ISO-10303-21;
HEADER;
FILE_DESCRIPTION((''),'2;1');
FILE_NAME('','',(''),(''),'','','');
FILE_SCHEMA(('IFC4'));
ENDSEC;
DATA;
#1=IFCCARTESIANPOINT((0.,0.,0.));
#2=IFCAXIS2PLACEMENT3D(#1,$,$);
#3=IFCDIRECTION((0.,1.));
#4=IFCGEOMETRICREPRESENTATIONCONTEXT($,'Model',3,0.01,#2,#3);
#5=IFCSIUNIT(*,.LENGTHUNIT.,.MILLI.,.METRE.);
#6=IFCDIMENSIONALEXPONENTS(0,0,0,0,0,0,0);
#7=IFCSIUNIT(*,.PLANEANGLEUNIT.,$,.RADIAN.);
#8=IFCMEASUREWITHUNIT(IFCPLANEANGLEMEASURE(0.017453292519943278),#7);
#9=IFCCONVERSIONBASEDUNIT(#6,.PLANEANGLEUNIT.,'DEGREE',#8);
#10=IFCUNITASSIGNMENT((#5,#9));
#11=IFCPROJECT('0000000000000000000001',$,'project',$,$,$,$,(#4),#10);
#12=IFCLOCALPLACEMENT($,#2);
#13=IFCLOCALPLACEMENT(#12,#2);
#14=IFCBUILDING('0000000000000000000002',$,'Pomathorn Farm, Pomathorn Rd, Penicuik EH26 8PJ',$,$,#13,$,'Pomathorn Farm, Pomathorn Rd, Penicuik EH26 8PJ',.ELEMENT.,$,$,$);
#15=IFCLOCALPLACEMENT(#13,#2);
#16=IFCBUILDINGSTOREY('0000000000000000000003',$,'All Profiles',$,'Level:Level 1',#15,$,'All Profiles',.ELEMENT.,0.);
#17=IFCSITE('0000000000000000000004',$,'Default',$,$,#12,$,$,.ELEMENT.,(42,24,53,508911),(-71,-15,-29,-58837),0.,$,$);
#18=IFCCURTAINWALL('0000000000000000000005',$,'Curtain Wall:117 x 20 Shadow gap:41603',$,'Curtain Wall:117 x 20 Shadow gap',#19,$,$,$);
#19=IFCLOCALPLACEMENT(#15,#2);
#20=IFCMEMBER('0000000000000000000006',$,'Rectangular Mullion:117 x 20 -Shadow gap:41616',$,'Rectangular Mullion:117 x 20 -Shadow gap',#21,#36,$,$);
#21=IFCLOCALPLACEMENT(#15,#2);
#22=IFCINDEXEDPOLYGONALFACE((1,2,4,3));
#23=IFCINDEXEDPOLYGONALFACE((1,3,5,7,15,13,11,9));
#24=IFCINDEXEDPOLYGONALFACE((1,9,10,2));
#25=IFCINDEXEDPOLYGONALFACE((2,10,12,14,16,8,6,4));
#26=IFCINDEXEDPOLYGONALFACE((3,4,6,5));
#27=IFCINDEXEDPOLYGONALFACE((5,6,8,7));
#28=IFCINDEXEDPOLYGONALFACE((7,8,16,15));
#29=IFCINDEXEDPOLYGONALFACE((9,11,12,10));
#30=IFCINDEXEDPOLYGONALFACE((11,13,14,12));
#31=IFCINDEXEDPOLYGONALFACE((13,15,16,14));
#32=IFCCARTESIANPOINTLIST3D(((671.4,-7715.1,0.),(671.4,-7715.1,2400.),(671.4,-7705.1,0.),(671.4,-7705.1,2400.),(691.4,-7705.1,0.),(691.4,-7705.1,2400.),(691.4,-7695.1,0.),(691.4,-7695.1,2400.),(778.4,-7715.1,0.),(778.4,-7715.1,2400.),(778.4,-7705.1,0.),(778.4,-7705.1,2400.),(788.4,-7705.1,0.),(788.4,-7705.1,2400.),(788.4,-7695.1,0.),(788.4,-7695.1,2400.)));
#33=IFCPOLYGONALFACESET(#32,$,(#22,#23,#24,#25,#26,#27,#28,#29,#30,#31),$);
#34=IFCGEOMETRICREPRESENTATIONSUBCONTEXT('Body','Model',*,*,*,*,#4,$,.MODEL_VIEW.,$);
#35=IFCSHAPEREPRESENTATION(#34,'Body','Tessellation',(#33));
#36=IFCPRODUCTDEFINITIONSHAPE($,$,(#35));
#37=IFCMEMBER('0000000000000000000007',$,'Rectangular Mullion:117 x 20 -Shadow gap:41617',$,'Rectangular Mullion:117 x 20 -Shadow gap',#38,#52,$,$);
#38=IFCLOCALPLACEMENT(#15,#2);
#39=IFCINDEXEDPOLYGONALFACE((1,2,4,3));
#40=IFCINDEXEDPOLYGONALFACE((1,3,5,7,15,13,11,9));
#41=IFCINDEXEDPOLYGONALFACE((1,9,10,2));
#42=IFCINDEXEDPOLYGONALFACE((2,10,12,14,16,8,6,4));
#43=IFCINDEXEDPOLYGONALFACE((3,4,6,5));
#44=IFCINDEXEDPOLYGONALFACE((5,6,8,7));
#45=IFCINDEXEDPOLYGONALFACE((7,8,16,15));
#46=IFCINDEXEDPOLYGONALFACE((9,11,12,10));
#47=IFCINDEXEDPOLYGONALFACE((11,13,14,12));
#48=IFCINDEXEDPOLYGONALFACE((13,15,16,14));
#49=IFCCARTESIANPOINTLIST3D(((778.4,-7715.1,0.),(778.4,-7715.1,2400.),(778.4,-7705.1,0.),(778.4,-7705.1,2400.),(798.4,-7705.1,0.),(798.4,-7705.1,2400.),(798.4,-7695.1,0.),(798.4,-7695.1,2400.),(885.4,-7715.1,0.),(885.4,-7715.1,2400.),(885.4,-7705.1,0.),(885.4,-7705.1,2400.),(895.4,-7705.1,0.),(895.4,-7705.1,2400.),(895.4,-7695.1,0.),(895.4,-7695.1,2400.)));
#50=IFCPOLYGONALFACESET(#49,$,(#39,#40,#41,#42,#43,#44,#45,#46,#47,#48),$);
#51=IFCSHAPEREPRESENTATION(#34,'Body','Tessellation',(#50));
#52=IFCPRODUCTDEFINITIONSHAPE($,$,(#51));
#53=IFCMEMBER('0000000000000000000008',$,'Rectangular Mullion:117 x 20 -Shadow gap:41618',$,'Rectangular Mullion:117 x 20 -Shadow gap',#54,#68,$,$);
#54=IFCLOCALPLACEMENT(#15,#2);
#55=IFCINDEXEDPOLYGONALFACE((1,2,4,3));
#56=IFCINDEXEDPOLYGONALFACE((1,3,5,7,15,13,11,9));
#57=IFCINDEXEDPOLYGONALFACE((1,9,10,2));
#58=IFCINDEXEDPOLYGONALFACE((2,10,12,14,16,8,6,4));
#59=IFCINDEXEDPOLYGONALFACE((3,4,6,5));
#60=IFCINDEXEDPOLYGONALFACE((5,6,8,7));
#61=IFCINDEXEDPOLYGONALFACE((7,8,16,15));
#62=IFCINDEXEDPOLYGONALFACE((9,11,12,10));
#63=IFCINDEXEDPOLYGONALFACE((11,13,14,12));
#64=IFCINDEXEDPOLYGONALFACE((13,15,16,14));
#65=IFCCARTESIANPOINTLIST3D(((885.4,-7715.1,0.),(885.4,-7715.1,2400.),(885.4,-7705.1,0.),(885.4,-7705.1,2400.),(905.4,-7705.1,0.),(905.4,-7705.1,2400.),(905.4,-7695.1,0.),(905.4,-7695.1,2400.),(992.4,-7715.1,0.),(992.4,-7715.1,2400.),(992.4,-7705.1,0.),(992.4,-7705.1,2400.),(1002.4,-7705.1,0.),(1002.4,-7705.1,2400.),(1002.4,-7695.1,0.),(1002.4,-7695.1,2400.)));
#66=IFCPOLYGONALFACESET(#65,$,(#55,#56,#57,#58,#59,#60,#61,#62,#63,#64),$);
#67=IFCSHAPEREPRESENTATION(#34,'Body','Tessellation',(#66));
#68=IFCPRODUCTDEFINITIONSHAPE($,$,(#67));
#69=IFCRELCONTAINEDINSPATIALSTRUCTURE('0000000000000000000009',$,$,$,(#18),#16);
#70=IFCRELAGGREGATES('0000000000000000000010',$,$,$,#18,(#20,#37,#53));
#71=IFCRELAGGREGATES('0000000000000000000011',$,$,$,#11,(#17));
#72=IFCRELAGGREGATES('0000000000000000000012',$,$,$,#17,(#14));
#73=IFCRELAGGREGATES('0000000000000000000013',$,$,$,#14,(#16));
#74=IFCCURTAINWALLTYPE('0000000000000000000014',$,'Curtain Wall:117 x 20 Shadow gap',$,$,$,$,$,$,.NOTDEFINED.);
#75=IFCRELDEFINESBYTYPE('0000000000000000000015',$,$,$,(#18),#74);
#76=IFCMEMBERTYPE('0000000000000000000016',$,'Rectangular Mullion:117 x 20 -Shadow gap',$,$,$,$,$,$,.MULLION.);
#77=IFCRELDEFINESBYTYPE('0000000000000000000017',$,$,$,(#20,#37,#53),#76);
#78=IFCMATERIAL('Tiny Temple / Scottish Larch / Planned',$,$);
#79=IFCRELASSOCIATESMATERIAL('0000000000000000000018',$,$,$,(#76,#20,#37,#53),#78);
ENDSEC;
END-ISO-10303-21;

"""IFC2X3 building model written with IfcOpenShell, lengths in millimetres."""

from ifc_helpers import new_model, entity, si_unit, converted_unit, direction, frame, origin, place, context, subcontext, project, spatial, polyline, outline, extrude, source, transform, mapped, material, type_object, type_shapes, element, aggregate, save


model = new_model("IFC2X3")

# Units and contexts
model_context = context("Model", 3, precision=0.01, world=origin(), true_north=direction((0.0, 1.0)))
body_context = subcontext(model_context, "Body", "Model", "MODEL_VIEW")
ifc_project = project(units=[si_unit("LENGTHUNIT", "METRE", prefix="MILLI"), converted_unit("PLANEANGLEUNIT", "DEGREE", entity("IfcPlaneAngleMeasure", 0.017453292519943278), si_unit("PLANEANGLEUNIT", "RADIAN"), dimensions=[0, 0, 0, 0, 0, 0, 0])], contexts=[model_context])

# Site, building, storey
site_placement = place(None, origin())
site = spatial("IfcSite", under=ifc_project, at=site_placement, Name="Default", CompositionType="ELEMENT", RefLatitude=(42, 24, 53, 508911), RefLongitude=(-71, -15, -29, -58837), RefElevation=0.0)
building_placement = place(site_placement, origin())
building = spatial("IfcBuilding", under=site, at=building_placement, Name="Pomathorn Farm, Pomathorn Rd, Penicuik EH26 8PJ", LongName="Pomathorn Farm, Pomathorn Rd, Penicuik EH26 8PJ", CompositionType="ELEMENT")
storey_placement = place(building_placement, origin())
storey = spatial("IfcBuildingStorey", under=building, at=storey_placement, Name="All Profiles", ObjectType="Level:Level 1", LongName="All Profiles", CompositionType="ELEMENT", Elevation=0.0)

# Curtain wall, members
ifc_material = material(Name="Tiny Temple / Scottish Larch / Planned")
curtain_wall_type_1 = type_object("IfcCurtainWallType", Name="Curtain Wall:117 x 20 Shadow gap", PredefinedType="NOTDEFINED")
curtain_wall_1_placement = place(storey_placement, origin())
curtain_wall_1 = element("IfcCurtainWall", 1, at=curtain_wall_1_placement, inside=storey, type_object=curtain_wall_type_1, Name="Curtain Wall:117 x 20 Shadow gap:41603", ObjectType="Curtain Wall:117 x 20 Shadow gap")
member_type_1 = type_object("IfcMemberType", Name="Rectangular Mullion:117 x 20 -Shadow gap", PredefinedType="MULLION", material=ifc_material)
shared_shape_1 = source(origin(), body_context, "Body", "SweptSolid", [
    extrude(outline(polyline([(-61.0, 0.0), (-61.0, -10.0), (46.0, -10.0), (46.0, 0.0), (56.0, 0.0), (56.0, 10.0), (-41.0, 10.0), (-41.0, 0.0), (-61.0, 0.0)])), frame((-56.0, -10.0, -2400.0), z_axis=(0.0, 0.0, -1.0), x_axis=(1.0, 0.0, 0.0)), (0.0, 0.0, -1.0), 2400.0),
])
type_shapes(member_type_1, [shared_shape_1])
member_1_placement = place(curtain_wall_1_placement, frame((788.4, -7715.1, 0.0), z_axis=(0.0, 0.0, -1.0), x_axis=(1.0, 0.0, 0.0)))
member_1 = element("IfcMember", 2, at=member_1_placement, type_object=member_type_1, material=ifc_material, Name="Rectangular Mullion:117 x 20 -Shadow gap:41616", ObjectType="Rectangular Mullion:117 x 20 -Shadow gap", context=body_context, shape_type="MappedRepresentation", body=[
    mapped(shared_shape_1, transform((0.0, 0.0, 0.0), scale=1.0)),
])
member_2_placement = place(curtain_wall_1_placement, frame((895.4, -7715.1, 0.0), z_axis=(0.0, 0.0, -1.0), x_axis=(1.0, 0.0, 0.0)))
member_2 = element("IfcMember", 3, at=member_2_placement, type_object=member_type_1, material=ifc_material, Name="Rectangular Mullion:117 x 20 -Shadow gap:41617", ObjectType="Rectangular Mullion:117 x 20 -Shadow gap", context=body_context, shape_type="MappedRepresentation", body=[
    mapped(shared_shape_1, transform((0.0, 0.0, 0.0), scale=1.0)),
])
member_3_placement = place(curtain_wall_1_placement, frame((1002.4, -7715.1, 0.0), z_axis=(0.0, 0.0, -1.0), x_axis=(1.0, 0.0, 0.0)))
member_3 = element("IfcMember", 4, at=member_3_placement, type_object=member_type_1, material=ifc_material, Name="Rectangular Mullion:117 x 20 -Shadow gap:41618", ObjectType="Rectangular Mullion:117 x 20 -Shadow gap", context=body_context, shape_type="MappedRepresentation", body=[
    mapped(shared_shape_1, transform((0.0, 0.0, 0.0), scale=1.0)),
])
aggregate(curtain_wall_1, [member_1, member_2, member_3])

save(model, "model.ifc")
